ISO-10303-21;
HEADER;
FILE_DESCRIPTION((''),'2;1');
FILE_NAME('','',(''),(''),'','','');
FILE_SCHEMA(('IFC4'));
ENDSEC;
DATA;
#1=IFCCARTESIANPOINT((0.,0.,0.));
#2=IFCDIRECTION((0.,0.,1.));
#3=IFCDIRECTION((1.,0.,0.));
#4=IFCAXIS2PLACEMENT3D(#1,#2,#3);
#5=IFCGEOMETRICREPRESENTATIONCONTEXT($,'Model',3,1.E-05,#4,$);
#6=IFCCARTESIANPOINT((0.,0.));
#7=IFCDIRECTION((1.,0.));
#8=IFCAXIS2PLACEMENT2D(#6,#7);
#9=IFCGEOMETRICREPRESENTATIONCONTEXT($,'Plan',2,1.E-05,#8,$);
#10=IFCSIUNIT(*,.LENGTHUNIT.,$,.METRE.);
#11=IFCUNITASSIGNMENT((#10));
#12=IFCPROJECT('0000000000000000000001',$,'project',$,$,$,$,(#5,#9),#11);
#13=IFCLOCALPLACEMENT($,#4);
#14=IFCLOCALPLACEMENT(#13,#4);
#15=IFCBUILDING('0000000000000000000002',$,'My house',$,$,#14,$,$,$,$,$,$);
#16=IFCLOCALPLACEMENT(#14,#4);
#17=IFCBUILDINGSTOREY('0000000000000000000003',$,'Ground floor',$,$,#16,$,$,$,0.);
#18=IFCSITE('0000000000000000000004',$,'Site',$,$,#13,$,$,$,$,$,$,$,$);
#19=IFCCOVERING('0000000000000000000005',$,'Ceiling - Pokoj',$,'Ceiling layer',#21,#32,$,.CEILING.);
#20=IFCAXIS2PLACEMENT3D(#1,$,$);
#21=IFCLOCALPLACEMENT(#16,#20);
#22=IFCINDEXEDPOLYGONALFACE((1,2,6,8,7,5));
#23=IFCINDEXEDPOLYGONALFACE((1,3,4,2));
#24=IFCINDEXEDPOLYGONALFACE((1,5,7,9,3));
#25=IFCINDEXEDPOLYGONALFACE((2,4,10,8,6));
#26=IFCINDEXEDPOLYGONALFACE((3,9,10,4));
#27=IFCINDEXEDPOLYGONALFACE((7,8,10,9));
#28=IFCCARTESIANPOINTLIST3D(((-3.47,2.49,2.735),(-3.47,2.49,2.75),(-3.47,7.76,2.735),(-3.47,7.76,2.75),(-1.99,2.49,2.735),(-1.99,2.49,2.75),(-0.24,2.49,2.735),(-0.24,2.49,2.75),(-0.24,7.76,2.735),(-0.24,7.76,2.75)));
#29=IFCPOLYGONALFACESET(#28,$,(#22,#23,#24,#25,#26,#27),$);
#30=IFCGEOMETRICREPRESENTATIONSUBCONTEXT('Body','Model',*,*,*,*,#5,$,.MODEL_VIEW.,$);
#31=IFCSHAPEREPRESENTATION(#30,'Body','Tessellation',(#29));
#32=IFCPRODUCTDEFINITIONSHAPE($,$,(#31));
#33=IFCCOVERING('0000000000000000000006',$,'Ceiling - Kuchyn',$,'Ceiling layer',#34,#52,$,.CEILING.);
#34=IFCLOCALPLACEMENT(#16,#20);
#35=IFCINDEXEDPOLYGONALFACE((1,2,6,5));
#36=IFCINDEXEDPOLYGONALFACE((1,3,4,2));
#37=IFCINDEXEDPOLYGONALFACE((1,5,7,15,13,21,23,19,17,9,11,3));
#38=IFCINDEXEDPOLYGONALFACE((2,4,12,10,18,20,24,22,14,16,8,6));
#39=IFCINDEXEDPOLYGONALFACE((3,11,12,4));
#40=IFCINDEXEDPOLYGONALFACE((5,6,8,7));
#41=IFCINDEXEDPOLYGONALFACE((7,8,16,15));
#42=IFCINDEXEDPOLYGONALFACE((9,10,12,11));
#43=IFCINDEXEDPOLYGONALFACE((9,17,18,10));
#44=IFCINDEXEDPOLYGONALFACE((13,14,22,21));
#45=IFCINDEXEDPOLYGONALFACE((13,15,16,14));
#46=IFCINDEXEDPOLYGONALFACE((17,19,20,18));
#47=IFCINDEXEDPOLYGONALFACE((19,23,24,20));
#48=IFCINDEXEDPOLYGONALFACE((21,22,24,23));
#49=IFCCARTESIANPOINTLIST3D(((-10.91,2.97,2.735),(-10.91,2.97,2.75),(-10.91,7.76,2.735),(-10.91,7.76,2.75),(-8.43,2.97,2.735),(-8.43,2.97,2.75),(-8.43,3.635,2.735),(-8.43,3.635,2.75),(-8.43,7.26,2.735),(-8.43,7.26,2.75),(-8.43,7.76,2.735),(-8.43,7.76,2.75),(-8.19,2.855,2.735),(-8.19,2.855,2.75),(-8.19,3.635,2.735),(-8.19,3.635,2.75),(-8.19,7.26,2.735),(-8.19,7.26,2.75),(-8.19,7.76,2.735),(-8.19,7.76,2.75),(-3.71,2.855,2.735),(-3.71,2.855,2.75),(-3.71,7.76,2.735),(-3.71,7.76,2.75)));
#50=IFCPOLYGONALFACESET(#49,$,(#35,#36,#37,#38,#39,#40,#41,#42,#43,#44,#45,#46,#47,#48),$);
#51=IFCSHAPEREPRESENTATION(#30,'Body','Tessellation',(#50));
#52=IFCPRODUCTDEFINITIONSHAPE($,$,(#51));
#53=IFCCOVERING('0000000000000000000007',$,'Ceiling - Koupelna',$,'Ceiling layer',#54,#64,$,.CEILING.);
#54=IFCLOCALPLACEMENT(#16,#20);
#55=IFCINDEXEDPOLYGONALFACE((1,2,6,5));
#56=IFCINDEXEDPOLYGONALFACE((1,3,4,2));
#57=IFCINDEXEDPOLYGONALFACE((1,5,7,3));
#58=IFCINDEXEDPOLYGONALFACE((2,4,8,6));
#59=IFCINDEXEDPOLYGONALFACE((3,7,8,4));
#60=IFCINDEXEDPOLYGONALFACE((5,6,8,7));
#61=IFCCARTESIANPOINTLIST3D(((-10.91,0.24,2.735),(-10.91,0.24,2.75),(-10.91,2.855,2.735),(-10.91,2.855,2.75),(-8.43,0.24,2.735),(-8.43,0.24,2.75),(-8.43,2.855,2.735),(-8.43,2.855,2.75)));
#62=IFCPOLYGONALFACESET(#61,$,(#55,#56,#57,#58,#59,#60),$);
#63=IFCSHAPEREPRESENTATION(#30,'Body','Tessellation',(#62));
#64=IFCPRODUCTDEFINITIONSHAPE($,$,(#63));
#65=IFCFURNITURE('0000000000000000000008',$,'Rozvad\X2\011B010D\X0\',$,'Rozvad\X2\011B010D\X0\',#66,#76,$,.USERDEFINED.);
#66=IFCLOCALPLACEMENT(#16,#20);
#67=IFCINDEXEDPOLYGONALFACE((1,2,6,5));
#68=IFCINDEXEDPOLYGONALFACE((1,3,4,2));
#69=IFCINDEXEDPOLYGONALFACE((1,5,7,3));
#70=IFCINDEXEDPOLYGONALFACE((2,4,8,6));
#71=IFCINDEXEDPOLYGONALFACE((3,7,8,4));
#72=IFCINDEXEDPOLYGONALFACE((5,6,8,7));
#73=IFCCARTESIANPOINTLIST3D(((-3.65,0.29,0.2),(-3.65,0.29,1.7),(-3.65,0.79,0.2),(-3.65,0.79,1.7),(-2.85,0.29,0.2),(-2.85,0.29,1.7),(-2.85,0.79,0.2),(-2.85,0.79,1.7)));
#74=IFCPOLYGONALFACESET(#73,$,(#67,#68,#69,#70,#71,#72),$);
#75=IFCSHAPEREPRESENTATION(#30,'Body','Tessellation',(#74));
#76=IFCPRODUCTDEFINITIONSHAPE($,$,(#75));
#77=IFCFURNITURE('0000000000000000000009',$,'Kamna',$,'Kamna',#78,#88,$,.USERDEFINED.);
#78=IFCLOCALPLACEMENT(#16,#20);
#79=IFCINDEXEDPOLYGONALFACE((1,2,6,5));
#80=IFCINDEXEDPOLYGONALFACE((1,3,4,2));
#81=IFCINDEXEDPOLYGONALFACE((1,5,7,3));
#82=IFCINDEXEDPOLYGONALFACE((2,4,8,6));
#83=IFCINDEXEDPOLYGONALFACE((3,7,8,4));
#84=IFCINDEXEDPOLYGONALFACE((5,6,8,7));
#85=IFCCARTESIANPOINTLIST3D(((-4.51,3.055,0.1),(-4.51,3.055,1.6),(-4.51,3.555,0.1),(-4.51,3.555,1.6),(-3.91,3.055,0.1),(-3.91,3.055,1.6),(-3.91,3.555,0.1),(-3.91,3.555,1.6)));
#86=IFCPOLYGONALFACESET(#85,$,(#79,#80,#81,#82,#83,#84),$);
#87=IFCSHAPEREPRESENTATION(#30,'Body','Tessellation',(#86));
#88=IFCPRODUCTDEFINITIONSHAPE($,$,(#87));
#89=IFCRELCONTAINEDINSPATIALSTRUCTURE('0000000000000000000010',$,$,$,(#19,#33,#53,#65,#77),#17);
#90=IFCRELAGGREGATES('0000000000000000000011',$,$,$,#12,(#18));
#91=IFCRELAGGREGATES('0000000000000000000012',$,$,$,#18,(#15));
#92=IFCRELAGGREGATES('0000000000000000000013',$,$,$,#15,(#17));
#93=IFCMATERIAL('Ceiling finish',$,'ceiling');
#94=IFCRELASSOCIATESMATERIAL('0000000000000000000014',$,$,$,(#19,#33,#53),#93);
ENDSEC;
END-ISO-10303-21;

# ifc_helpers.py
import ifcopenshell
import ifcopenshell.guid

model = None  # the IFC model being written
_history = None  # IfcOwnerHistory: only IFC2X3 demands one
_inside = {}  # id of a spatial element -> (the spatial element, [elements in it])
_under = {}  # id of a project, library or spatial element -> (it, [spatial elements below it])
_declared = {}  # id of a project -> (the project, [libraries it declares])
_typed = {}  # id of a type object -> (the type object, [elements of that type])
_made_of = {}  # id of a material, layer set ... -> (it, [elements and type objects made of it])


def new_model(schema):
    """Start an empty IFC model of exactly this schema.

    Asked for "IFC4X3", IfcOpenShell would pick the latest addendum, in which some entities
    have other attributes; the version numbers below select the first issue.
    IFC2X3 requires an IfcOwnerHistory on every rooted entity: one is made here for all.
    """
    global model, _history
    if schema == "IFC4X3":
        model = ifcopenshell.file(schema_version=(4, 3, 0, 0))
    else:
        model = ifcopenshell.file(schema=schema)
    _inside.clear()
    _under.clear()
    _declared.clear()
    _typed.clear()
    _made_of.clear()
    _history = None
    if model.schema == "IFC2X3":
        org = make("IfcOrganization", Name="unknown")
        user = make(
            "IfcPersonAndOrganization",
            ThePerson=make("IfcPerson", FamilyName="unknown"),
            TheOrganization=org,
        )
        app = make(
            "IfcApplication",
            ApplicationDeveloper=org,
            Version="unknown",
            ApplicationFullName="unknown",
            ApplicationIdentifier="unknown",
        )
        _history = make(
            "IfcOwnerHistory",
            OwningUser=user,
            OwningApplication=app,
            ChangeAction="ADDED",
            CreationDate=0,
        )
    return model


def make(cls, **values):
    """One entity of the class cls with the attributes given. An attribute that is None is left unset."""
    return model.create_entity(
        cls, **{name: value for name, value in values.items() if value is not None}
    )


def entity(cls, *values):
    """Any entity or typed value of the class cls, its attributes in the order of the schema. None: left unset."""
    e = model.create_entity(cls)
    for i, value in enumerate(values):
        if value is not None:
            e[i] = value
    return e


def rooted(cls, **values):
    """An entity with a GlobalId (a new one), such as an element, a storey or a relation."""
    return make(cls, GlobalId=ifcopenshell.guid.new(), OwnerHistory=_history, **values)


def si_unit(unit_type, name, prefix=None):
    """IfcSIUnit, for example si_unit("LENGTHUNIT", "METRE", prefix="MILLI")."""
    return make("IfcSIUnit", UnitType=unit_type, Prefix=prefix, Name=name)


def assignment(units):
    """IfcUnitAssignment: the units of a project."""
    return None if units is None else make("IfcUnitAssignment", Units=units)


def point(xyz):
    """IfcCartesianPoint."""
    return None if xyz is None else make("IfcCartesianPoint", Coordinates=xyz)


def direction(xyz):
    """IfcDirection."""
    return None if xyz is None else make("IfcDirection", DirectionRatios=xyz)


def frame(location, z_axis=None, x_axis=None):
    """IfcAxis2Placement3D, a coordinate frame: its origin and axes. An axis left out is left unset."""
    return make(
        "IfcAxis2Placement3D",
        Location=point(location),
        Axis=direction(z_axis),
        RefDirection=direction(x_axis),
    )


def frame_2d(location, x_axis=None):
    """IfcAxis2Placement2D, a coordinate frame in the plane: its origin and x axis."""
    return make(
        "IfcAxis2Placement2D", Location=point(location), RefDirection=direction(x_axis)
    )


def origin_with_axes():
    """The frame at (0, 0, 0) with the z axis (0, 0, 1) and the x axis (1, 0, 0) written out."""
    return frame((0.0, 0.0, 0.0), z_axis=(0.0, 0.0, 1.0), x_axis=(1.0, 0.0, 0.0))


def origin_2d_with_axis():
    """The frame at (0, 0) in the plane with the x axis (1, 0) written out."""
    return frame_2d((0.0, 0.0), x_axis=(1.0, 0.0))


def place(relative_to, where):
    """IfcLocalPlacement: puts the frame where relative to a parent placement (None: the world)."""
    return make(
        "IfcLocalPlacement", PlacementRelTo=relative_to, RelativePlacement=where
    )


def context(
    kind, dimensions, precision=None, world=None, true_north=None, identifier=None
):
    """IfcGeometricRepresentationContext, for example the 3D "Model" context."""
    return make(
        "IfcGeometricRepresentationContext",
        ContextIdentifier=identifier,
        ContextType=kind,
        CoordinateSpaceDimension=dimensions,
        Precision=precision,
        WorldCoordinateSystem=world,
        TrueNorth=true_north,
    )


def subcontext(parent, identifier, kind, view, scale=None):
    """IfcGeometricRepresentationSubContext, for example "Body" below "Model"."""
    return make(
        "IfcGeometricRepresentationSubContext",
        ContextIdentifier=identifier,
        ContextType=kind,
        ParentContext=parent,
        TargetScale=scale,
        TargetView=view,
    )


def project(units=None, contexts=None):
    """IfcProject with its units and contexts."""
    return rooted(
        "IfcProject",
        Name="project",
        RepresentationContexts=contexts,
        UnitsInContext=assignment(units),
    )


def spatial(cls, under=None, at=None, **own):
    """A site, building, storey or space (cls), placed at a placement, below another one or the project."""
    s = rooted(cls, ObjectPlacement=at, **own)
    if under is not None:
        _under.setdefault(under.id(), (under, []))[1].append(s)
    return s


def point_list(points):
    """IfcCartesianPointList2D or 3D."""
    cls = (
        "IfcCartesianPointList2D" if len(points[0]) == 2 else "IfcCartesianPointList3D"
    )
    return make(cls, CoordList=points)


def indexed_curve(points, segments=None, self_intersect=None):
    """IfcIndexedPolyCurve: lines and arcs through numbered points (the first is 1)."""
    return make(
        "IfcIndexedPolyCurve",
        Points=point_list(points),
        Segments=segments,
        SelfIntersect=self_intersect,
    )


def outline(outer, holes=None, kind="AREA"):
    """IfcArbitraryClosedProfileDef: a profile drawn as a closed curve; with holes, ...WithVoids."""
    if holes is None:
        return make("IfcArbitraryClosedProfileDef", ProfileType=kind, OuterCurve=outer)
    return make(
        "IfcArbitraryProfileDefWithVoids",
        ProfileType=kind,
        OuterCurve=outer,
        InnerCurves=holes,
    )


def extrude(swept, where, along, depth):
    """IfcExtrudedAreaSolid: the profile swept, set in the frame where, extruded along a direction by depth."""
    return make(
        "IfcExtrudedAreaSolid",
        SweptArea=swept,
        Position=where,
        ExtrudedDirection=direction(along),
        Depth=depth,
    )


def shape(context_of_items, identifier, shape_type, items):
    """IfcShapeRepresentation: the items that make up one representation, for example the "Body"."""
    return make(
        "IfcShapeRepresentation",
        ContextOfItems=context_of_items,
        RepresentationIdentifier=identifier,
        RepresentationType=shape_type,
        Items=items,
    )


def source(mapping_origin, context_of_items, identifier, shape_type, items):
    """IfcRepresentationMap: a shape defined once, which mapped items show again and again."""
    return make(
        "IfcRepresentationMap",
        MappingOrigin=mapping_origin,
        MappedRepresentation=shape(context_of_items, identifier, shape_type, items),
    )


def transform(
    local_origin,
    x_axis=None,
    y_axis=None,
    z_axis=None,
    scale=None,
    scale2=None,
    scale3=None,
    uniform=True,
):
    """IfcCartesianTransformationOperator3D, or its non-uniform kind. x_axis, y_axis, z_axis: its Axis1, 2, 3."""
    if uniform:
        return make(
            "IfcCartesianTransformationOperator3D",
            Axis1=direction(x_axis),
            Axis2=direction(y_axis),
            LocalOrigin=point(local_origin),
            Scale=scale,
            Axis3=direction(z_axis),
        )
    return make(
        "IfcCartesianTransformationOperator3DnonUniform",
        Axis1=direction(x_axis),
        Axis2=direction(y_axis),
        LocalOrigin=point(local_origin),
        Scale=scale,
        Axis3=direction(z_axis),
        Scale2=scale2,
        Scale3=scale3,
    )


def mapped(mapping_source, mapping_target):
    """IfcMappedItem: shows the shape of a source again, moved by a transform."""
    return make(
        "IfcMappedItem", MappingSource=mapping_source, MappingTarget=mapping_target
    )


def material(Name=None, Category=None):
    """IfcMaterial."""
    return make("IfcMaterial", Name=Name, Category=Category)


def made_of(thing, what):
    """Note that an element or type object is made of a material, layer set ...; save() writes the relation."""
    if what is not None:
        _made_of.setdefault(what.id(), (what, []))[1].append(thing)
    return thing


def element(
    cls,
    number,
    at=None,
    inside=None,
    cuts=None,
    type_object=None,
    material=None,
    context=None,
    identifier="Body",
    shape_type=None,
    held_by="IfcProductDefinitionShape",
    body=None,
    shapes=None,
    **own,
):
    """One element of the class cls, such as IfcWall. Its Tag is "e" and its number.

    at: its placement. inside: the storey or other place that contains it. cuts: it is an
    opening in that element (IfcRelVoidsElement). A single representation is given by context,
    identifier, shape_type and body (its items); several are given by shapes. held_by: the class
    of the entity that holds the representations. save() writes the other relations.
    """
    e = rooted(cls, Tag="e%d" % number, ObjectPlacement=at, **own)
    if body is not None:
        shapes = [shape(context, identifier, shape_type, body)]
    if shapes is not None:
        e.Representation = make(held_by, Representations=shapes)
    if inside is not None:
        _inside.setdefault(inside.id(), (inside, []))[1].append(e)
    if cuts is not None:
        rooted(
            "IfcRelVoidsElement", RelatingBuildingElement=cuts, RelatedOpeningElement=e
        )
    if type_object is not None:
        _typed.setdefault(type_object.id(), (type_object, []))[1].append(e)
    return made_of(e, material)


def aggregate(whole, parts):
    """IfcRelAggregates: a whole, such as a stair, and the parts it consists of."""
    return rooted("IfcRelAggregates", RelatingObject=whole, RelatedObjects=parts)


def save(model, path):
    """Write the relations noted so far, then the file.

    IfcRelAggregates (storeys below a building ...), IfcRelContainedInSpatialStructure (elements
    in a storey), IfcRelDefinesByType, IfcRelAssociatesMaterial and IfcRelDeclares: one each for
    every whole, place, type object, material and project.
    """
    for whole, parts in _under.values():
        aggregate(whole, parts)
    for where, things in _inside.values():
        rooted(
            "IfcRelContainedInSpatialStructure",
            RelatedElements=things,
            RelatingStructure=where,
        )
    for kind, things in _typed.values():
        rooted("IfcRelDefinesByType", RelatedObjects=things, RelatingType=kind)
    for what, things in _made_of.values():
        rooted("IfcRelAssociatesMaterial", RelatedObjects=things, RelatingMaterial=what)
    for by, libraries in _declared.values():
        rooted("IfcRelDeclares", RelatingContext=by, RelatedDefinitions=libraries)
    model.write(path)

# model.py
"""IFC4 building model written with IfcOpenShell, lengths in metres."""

from ifc_helpers import new_model, entity, si_unit, frame, origin_with_axes, origin_2d_with_axis, place, context, subcontext, project, spatial, indexed_curve, outline, extrude, shape, source, transform, mapped, material, element, save


model = new_model("IFC4")

# Units and contexts
model_context = context("Model", 3, precision=1e-05, world=origin_with_axes())
plan_context = context("Plan", 2, precision=1e-05, world=origin_2d_with_axis())
body_context_1 = subcontext(model_context, "Body", "Model", "MODEL_VIEW")
body_context_2 = subcontext(plan_context, "Body", "Plan", "PLAN_VIEW")
ifc_project = project(units=[si_unit("LENGTHUNIT", "METRE")], contexts=[model_context, plan_context])

# Site, building, storey
site_placement = place(None, origin_with_axes())
site = spatial("IfcSite", under=ifc_project, at=site_placement, Name="Site")
building_placement = place(site_placement, origin_with_axes())
building = spatial("IfcBuilding", under=site, at=building_placement, Name="My house")
storey_placement = place(building_placement, origin_with_axes())
storey = spatial("IfcBuildingStorey", under=building, at=storey_placement, Name="Ground floor", Elevation=0.0)

# Coverings
ifc_material_1 = material(Name="Ceiling finish", Category="ceiling")
shared_shape_1 = source(origin_with_axes(), body_context_1, "Body", "SweptSolid", [
    extrude(outline(indexed_curve([(0.24, 2.49), (1.99, 2.49), (3.47, 2.49), (3.47, 7.76), (0.24, 7.76)])), None, (0.0, 0.0, 1.0), 0.015),
])
covering_1_placement = place(storey_placement, frame((0.0, 0.0, 2.735), z_axis=(0.0, 0.0, 1.0), x_axis=(1.0, 0.0, 0.0)))
element("IfcCovering", 1, at=covering_1_placement, inside=storey, material=ifc_material_1, Name="Ceiling - Pokoj", ObjectType="Ceiling layer", PredefinedType="CEILING", context=body_context_1, shape_type="MappedRepresentation", body=[
    mapped(shared_shape_1, transform((0.0, 0.0, 0.0), x_axis=(-1.0, 0.0, 0.0), y_axis=(0.0, 1.0, 0.0), z_axis=(0.0, 0.0, 1.0), scale=1.0)),
])
shared_shape_2 = source(origin_with_axes(), body_context_1, "Body", "SweptSolid", [
    extrude(outline(indexed_curve([(3.71, 2.855), (8.19, 2.855), (8.19, 3.635), (8.43, 3.635), (8.43, 2.97), (10.91, 2.97), (10.91, 7.76), (8.43, 7.76), (8.43, 7.26), (8.19, 7.26), (8.19, 7.76), (3.71, 7.76)])), None, (0.0, 0.0, 1.0), 0.015),
])
covering_2_placement = place(storey_placement, frame((0.0, 0.0, 2.735), z_axis=(0.0, 0.0, 1.0), x_axis=(1.0, 0.0, 0.0)))
element("IfcCovering", 2, at=covering_2_placement, inside=storey, material=ifc_material_1, Name="Ceiling - Kuchyn", ObjectType="Ceiling layer", PredefinedType="CEILING", context=body_context_1, shape_type="MappedRepresentation", body=[
    mapped(shared_shape_2, transform((0.0, 0.0, 0.0), x_axis=(-1.0, 0.0, 0.0), y_axis=(0.0, 1.0, 0.0), z_axis=(0.0, 0.0, 1.0), scale=1.0)),
])
shared_shape_3 = source(origin_with_axes(), body_context_1, "Body", "SweptSolid", [
    extrude(outline(indexed_curve([(8.43, 0.24), (10.91, 0.24), (10.91, 2.855), (8.43, 2.855)])), None, (0.0, 0.0, 1.0), 0.015),
])
covering_3_placement = place(storey_placement, frame((0.0, 0.0, 2.735), z_axis=(0.0, 0.0, 1.0), x_axis=(1.0, 0.0, 0.0)))
element("IfcCovering", 3, at=covering_3_placement, inside=storey, material=ifc_material_1, Name="Ceiling - Koupelna", ObjectType="Ceiling layer", PredefinedType="CEILING", context=body_context_1, shape_type="MappedRepresentation", body=[
    mapped(shared_shape_3, transform((0.0, 0.0, 0.0), x_axis=(-1.0, 0.0, 0.0), y_axis=(0.0, 1.0, 0.0), z_axis=(0.0, 0.0, 1.0), scale=1.0)),
])

# Furniture
shared_shape_4 = source(origin_with_axes(), body_context_1, "Body", "SweptSolid", [
    extrude(outline(indexed_curve([(-0.4, -0.25), (0.4, -0.25), (0.4, 0.25), (-0.4, 0.25)])), None, (0.0, 0.0, 1.0), 1.5),
])
shared_shape_5 = source(origin_with_axes(), body_context_2, "Body", "Curve2D", [
    entity("IfcIndexedPolyCurve", entity("IfcCartesianPointList2D", [[-0.4, -0.25], [0.4, -0.25], [0.4, 0.25], [-0.4, 0.25], [-0.4, -0.25]]), None, False),
])
furniture_1_placement = place(storey_placement, frame((-3.25, 0.54, 0.2), z_axis=(0.0, 0.0, 1.0), x_axis=(1.0, 0.0, 0.0)))
element("IfcFurniture", 4, at=furniture_1_placement, inside=storey, Name="Rozvaděč", ObjectType="Rozvaděč", PredefinedType="USERDEFINED", shapes=[
    shape(body_context_1, "Body", "MappedRepresentation", [mapped(shared_shape_4, transform((0.0, 0.0, 0.0), x_axis=(-1.0, 0.0, 0.0), y_axis=(0.0, 1.0, 0.0), z_axis=(0.0, 0.0, 1.0), scale=1.0))]),
    shape(body_context_2, "Body", "MappedRepresentation", [mapped(shared_shape_5, transform((0.0, 0.0, 0.0), x_axis=(-1.0, 0.0, 0.0), y_axis=(0.0, 1.0, 0.0), z_axis=(0.0, 0.0, 1.0), scale=1.0))]),
])
shared_shape_6 = source(origin_with_axes(), body_context_1, "Body", "SweptSolid", [
    extrude(outline(indexed_curve([(-0.3, -0.25), (0.3, -0.25), (0.3, 0.25), (-0.3, 0.25)])), None, (0.0, 0.0, 1.0), 1.5),
])
shared_shape_7 = source(origin_with_axes(), body_context_2, "Body", "Curve2D", [
    entity("IfcIndexedPolyCurve", entity("IfcCartesianPointList2D", [[-0.3, -0.25], [0.3, -0.25], [0.3, 0.25], [-0.3, 0.25], [-0.3, -0.25]]), None, False),
])
furniture_2_placement = place(storey_placement, frame((-4.21, 3.305, 0.1), z_axis=(0.0, 0.0, 1.0), x_axis=(1.0, 0.0, 0.0)))
element("IfcFurniture", 5, at=furniture_2_placement, inside=storey, Name="Kamna", ObjectType="Kamna", PredefinedType="USERDEFINED", shapes=[
    shape(body_context_1, "Body", "MappedRepresentation", [mapped(shared_shape_6, transform((0.0, 0.0, 0.0), x_axis=(-1.0, 0.0, 0.0), y_axis=(0.0, 1.0, 0.0), z_axis=(0.0, 0.0, 1.0), scale=1.0))]),
    shape(body_context_2, "Body", "MappedRepresentation", [mapped(shared_shape_7, transform((0.0, 0.0, 0.0), x_axis=(-1.0, 0.0, 0.0), y_axis=(0.0, 1.0, 0.0), z_axis=(0.0, 0.0, 1.0), scale=1.0))]),
])

save(model, "model.ifc")
